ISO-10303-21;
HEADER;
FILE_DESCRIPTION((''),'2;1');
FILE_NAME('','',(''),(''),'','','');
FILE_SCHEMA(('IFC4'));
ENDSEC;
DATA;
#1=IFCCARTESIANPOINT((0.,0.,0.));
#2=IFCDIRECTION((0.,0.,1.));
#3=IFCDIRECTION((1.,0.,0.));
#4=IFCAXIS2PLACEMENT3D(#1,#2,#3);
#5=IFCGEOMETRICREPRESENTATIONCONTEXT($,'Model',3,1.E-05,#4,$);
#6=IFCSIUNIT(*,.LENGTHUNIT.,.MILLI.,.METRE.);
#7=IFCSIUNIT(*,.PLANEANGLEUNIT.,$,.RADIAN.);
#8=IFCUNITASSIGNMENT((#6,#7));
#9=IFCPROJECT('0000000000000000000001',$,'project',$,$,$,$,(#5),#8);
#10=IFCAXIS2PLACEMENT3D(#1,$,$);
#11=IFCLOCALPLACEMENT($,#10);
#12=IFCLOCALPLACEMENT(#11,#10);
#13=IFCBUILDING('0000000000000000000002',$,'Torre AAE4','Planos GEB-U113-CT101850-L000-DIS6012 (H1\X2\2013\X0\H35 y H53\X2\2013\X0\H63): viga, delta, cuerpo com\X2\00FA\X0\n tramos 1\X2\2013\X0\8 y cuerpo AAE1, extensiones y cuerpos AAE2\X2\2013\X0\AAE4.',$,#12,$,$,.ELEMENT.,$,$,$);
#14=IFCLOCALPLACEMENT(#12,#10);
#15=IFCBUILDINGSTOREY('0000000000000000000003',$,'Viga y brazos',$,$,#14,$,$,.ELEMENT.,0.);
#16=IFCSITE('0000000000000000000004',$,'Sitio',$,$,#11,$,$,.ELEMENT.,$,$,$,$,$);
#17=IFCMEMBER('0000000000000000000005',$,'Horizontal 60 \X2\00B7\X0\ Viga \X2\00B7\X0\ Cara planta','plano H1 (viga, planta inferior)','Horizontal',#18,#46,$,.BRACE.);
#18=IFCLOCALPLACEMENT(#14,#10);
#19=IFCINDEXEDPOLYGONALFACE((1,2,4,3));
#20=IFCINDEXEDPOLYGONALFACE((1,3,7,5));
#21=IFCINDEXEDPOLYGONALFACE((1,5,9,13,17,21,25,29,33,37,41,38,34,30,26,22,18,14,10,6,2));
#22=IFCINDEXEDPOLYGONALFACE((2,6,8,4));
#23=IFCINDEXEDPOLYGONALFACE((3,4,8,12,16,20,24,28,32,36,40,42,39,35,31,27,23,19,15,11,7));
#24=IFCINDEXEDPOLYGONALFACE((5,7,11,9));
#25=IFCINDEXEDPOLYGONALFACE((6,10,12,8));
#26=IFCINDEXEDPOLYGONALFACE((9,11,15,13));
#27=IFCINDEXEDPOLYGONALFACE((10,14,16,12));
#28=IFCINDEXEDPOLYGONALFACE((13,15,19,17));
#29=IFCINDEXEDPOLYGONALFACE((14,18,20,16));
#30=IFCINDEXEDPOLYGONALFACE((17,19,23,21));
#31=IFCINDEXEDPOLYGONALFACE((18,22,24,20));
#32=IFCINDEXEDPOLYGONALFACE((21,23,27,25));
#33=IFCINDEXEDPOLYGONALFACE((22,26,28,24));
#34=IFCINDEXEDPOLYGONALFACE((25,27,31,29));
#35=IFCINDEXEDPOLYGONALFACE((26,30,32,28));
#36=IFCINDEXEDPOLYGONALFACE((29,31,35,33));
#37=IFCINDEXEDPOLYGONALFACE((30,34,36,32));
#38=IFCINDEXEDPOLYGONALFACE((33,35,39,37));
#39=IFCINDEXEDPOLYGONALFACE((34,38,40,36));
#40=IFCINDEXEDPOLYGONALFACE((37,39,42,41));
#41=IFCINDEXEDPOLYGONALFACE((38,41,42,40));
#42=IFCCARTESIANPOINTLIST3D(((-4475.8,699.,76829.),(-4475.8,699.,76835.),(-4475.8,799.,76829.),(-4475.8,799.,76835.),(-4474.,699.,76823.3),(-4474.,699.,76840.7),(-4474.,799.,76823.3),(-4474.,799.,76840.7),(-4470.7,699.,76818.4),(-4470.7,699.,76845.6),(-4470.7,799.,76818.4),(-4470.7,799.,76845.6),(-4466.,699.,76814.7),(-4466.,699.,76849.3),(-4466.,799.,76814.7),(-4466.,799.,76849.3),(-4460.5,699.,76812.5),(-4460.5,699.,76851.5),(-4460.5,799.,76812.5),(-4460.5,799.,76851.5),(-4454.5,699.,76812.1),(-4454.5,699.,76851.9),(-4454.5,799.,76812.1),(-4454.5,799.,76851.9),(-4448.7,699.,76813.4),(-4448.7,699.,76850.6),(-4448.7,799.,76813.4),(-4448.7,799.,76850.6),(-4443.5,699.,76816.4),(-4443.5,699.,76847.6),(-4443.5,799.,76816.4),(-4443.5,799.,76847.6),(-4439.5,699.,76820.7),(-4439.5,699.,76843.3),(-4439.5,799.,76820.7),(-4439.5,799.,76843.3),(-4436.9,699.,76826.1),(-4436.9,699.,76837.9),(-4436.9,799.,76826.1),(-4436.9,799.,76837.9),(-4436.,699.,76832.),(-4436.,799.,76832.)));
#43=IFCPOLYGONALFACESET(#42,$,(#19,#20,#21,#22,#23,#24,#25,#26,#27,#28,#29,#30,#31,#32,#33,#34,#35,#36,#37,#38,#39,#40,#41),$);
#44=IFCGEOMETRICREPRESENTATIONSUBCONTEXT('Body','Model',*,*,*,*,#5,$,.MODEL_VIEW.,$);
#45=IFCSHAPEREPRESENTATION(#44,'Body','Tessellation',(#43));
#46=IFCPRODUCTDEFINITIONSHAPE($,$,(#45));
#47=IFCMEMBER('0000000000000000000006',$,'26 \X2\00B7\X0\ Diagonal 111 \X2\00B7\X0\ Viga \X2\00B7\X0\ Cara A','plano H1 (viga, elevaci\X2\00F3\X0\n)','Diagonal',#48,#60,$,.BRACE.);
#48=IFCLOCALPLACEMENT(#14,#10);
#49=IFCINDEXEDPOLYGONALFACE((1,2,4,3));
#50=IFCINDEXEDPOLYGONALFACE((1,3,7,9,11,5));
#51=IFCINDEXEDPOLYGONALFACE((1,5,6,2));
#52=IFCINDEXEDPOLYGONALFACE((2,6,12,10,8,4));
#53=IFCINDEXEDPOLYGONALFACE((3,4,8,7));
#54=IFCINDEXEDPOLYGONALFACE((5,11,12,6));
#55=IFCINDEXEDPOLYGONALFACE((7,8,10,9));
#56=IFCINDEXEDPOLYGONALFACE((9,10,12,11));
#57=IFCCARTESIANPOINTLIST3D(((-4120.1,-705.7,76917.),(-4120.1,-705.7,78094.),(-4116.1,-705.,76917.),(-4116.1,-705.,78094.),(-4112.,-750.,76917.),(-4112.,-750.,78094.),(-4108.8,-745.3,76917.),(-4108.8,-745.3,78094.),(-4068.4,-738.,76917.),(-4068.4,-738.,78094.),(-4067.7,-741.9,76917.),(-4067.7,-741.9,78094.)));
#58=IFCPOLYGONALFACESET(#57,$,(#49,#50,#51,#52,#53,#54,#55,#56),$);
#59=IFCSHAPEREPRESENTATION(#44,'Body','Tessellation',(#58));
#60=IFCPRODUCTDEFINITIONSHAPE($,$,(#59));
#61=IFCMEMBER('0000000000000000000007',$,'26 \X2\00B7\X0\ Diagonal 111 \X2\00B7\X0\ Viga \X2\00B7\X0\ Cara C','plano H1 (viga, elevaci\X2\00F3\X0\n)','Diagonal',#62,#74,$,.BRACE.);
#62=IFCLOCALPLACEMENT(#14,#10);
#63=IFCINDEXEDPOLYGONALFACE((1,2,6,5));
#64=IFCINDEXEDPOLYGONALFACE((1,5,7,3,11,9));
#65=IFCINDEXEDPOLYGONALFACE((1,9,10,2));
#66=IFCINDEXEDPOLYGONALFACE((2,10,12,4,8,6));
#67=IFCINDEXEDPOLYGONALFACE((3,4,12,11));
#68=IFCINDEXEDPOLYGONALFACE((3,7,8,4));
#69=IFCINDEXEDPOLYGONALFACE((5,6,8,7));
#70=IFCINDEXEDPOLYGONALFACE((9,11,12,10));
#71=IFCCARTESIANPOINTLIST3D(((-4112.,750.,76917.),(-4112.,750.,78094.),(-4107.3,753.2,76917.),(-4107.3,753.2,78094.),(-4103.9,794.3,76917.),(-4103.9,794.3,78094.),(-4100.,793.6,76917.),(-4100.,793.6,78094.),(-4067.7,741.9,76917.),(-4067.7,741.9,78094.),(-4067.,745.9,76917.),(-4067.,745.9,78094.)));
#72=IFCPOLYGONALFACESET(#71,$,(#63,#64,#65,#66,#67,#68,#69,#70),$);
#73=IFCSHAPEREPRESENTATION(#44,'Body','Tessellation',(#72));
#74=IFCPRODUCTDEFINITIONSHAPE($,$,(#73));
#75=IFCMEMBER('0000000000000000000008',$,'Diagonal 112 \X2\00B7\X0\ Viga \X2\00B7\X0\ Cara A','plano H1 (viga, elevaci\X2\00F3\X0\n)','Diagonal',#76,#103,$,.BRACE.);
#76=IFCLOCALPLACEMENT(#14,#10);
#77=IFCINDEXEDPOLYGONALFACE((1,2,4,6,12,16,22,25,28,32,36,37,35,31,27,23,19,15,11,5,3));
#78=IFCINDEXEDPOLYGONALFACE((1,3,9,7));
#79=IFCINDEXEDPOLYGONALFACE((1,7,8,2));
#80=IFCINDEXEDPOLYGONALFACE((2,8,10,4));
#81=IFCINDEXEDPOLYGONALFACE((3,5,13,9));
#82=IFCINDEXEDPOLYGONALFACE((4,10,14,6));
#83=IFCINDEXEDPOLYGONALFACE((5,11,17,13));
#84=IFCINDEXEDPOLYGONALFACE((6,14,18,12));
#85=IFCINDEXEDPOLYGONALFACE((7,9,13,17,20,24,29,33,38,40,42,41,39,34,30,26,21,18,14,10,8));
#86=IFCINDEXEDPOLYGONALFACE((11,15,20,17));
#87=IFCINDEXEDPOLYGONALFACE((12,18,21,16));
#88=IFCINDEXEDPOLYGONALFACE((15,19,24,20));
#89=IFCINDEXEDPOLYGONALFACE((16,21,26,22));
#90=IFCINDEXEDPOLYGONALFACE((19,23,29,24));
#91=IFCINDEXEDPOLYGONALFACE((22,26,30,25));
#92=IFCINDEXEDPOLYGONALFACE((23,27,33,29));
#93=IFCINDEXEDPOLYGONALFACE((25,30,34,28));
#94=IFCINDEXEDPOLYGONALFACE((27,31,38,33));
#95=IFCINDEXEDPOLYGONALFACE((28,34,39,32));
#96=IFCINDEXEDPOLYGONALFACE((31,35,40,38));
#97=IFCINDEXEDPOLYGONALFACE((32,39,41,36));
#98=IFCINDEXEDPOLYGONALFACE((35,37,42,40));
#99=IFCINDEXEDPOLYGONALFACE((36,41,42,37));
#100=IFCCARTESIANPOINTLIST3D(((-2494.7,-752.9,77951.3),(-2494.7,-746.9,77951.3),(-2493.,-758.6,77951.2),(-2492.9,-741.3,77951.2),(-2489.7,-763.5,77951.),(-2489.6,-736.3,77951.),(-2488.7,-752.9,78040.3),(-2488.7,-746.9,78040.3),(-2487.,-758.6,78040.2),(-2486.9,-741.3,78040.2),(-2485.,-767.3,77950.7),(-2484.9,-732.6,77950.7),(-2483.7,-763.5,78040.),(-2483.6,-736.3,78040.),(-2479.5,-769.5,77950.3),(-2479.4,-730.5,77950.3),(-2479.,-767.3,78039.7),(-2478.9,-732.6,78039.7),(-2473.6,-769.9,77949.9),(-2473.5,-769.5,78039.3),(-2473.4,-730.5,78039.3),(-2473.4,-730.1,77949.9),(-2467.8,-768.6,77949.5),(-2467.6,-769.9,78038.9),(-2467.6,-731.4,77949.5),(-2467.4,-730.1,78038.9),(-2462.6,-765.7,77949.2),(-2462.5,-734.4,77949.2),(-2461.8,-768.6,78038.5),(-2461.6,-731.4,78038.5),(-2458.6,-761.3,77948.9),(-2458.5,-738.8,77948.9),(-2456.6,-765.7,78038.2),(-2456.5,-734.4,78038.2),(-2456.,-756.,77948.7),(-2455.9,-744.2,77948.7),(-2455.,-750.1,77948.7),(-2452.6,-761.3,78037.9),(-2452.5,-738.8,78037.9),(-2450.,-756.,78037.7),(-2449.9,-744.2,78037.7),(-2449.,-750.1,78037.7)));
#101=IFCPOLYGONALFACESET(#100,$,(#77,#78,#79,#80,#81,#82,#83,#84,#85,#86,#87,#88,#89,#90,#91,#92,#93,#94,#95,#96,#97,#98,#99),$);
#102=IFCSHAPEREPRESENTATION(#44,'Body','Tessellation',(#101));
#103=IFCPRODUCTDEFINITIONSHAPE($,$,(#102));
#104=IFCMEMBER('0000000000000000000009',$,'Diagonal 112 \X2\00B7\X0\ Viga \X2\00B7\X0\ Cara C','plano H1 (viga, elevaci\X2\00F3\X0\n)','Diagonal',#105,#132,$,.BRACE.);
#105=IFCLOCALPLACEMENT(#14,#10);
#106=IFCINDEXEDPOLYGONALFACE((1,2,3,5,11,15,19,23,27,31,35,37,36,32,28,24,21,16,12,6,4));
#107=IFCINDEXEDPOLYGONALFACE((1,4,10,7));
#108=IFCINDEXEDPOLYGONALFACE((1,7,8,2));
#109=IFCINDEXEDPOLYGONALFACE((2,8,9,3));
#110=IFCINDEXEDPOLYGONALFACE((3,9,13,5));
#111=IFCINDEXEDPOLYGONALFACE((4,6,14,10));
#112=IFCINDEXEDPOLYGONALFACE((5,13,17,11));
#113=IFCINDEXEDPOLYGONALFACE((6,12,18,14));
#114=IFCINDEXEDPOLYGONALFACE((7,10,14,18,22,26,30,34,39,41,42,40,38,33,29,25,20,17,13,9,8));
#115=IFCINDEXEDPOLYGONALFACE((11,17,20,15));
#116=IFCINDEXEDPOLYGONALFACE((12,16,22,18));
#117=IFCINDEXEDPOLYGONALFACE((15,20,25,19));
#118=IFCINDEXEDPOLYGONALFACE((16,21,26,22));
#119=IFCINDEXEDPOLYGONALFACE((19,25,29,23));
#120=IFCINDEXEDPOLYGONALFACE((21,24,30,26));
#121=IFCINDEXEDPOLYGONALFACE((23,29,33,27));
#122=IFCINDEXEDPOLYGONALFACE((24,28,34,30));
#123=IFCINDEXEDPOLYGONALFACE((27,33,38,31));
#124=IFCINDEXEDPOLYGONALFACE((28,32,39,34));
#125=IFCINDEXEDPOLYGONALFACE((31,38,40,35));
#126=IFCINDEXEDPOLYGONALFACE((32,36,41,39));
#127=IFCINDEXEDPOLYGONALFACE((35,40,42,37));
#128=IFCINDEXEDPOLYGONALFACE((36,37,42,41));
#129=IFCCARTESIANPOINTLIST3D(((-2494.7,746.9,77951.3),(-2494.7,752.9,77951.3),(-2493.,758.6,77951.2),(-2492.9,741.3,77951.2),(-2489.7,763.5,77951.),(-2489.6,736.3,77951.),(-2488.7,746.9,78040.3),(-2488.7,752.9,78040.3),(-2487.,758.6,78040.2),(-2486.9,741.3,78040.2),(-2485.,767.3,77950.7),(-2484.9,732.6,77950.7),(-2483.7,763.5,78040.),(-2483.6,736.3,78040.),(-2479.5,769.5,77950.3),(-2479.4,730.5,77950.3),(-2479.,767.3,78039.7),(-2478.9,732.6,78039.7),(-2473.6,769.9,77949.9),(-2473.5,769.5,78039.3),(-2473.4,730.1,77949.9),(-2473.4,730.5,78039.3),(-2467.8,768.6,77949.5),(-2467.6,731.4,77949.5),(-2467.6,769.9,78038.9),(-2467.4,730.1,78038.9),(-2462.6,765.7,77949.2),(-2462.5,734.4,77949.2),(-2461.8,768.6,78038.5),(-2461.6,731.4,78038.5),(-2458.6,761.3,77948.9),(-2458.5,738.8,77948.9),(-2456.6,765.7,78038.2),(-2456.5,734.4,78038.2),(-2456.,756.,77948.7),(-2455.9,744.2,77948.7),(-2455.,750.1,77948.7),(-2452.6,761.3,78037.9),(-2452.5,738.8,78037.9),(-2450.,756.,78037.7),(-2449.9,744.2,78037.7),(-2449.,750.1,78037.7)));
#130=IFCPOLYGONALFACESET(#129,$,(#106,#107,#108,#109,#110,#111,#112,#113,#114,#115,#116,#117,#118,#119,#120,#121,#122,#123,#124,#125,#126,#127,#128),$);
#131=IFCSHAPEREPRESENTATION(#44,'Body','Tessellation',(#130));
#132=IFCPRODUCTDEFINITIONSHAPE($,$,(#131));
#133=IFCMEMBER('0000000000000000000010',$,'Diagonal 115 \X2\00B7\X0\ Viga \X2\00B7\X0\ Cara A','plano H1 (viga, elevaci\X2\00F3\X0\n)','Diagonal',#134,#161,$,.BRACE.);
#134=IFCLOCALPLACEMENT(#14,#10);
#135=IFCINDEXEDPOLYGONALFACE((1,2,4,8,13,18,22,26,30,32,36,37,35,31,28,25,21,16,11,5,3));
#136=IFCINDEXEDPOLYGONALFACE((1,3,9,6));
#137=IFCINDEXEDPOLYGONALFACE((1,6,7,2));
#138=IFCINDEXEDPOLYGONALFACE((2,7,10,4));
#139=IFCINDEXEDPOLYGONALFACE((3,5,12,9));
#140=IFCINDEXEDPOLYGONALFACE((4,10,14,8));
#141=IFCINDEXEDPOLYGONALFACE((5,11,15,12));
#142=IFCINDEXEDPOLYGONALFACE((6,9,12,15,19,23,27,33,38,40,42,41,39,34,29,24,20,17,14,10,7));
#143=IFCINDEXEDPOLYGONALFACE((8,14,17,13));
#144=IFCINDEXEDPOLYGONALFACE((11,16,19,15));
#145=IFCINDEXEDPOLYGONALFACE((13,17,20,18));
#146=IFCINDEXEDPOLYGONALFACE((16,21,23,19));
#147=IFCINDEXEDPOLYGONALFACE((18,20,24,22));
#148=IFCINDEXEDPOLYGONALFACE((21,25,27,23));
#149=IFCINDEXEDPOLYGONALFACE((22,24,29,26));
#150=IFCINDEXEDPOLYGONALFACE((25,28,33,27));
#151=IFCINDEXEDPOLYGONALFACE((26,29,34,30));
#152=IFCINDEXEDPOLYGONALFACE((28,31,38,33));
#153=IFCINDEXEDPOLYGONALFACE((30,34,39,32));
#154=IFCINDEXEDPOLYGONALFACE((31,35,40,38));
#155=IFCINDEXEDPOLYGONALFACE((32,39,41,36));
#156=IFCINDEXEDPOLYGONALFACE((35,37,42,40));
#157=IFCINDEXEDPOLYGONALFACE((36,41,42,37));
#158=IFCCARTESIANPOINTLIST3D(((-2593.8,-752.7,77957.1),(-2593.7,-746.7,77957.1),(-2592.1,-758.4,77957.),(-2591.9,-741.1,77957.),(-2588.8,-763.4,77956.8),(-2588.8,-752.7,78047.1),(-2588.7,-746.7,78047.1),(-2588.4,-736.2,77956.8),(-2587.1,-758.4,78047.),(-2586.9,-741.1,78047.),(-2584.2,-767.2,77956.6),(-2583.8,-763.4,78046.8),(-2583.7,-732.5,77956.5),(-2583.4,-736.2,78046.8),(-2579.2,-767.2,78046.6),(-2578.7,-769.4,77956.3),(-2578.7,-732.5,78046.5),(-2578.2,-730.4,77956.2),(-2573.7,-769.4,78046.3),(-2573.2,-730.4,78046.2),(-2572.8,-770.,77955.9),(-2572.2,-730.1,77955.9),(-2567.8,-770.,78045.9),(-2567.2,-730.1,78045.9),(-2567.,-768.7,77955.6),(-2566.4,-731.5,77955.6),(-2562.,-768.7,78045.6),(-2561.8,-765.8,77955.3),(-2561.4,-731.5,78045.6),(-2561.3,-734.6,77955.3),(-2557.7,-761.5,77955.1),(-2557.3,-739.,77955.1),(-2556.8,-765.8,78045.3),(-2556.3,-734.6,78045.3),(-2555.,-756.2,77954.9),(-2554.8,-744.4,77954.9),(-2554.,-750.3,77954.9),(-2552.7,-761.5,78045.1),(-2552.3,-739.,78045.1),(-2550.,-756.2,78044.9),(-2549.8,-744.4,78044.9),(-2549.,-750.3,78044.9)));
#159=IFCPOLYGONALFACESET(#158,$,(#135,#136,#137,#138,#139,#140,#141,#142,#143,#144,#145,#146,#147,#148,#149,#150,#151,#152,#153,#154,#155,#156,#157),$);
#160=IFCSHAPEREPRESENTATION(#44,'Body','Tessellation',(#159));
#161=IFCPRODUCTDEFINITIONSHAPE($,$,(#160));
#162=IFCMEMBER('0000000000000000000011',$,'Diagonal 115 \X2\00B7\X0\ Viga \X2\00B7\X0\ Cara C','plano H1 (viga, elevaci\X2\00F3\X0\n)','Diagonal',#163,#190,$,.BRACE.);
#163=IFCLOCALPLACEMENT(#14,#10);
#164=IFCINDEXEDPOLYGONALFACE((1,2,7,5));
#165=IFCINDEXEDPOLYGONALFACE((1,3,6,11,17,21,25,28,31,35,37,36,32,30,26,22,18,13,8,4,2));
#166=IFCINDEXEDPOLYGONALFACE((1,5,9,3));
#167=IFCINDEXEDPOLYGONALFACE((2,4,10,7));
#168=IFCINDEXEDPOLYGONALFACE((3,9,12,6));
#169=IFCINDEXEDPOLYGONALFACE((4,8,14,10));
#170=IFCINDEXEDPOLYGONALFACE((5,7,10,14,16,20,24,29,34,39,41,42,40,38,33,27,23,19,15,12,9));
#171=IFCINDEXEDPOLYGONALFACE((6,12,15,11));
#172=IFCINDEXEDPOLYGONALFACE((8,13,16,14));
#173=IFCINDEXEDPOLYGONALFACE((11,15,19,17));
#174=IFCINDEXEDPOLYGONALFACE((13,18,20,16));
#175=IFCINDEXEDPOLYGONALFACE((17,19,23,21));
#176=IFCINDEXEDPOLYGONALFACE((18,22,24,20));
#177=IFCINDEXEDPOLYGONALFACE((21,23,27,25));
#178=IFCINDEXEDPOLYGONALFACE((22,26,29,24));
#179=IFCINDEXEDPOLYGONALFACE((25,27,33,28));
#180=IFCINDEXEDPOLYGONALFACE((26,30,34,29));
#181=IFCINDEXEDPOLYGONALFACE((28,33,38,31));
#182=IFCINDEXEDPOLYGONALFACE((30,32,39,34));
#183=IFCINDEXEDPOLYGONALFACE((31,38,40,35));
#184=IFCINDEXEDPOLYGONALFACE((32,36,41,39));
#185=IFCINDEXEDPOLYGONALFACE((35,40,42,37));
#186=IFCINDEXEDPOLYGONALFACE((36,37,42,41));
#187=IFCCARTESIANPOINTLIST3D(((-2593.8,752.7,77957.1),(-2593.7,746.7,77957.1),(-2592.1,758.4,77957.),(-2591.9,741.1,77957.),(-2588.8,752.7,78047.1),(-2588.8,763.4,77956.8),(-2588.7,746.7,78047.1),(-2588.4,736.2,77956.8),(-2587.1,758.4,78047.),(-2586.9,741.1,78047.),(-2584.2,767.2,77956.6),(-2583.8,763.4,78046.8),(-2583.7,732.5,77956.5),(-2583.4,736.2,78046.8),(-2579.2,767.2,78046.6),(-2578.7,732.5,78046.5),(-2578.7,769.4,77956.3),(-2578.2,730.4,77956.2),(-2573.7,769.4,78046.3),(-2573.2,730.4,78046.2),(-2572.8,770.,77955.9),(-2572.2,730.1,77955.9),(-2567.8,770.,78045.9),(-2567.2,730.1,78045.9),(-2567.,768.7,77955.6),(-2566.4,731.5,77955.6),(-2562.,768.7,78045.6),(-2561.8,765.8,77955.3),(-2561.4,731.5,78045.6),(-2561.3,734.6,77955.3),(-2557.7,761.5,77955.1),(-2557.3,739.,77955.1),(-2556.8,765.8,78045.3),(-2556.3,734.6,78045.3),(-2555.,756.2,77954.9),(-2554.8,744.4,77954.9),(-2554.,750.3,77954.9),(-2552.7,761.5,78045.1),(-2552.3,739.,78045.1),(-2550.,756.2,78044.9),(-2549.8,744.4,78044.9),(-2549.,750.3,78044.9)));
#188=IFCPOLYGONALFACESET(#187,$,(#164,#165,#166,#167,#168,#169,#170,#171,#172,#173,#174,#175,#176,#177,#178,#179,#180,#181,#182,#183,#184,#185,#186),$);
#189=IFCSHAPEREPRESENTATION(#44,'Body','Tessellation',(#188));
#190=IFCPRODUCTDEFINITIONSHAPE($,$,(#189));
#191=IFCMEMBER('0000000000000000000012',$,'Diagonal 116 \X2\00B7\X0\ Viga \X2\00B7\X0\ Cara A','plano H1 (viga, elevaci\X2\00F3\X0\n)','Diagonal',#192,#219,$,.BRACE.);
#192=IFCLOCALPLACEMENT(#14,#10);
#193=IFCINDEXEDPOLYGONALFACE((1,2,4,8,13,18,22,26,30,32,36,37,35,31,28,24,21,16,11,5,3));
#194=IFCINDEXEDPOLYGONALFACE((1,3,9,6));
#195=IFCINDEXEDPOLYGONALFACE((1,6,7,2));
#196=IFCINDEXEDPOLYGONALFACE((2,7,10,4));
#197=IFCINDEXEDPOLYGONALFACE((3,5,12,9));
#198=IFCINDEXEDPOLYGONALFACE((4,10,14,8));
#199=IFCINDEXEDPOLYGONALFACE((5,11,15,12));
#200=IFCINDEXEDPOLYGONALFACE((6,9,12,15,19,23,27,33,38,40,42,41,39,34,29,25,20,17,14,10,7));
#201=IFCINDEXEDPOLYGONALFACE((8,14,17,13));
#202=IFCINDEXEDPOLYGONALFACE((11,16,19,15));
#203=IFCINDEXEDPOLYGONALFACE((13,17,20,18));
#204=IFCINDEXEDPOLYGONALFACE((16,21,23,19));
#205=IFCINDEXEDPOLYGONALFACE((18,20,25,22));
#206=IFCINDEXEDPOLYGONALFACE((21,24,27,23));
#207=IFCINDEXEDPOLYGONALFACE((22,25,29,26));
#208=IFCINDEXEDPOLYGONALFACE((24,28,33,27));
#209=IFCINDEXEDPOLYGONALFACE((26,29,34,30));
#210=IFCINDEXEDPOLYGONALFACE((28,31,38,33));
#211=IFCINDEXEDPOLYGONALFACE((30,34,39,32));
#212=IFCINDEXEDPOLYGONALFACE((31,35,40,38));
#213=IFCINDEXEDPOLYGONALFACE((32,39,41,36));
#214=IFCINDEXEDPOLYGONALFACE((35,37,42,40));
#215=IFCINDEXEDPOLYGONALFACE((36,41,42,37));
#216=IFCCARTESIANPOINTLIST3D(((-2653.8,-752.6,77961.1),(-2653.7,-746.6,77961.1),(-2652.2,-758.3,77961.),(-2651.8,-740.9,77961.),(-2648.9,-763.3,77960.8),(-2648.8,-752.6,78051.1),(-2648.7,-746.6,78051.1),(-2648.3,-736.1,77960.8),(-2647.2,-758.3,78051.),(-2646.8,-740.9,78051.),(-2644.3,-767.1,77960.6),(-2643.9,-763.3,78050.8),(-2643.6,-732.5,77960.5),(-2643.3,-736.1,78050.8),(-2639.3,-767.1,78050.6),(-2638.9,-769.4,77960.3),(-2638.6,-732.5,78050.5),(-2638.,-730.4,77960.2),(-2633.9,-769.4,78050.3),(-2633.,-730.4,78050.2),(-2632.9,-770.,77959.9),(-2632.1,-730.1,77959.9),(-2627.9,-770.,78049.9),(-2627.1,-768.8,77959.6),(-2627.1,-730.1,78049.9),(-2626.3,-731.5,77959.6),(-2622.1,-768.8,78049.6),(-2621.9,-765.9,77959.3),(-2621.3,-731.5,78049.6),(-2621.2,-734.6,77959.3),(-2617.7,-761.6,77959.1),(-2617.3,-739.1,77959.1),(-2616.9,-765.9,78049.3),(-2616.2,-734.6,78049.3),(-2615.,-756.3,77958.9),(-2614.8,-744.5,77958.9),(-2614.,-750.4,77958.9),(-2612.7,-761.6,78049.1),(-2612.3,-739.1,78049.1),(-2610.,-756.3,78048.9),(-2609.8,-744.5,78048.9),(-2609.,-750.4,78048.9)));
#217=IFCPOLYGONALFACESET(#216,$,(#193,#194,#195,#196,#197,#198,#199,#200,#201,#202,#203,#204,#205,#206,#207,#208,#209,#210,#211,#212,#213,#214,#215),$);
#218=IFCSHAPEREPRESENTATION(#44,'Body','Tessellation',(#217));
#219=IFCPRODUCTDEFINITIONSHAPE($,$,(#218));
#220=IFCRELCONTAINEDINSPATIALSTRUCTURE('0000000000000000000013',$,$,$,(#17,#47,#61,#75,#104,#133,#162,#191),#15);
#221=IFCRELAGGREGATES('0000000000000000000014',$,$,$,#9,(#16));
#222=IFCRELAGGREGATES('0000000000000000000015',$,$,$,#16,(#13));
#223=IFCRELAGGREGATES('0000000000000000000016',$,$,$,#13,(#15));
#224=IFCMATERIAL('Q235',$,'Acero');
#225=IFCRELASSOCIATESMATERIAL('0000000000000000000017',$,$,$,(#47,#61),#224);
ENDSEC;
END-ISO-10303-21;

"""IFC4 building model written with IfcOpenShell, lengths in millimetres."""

from ifc_helpers import new_model, si_unit, frame, frame_2d, origin, origin_with_axes, place, context, subcontext, project, spatial, circle, l_section, extrude, material, element, save


model = new_model("IFC4")

# Units and contexts
model_context = context("Model", 3, precision=1e-05, world=origin_with_axes())
body_context = subcontext(model_context, "Body", "Model", "MODEL_VIEW")
ifc_project = project(units=[si_unit("LENGTHUNIT", "METRE", prefix="MILLI"), si_unit("PLANEANGLEUNIT", "RADIAN")], contexts=[model_context])

# Site, building, storey
site_placement = place(None, origin())
site = spatial("IfcSite", under=ifc_project, at=site_placement, Name="Sitio", CompositionType="ELEMENT")
building_placement = place(site_placement, origin())
building = spatial("IfcBuilding", under=site, at=building_placement, Name="Torre AAE4", Description="Planos GEB-U113-CT101850-L000-DIS6012 (H1–H35 y H53–H63): viga, delta, cuerpo común tramos 1–8 y cuerpo AAE1, extensiones y cuerpos AAE2–AAE4.", CompositionType="ELEMENT")
storey_placement = place(building_placement, origin())
storey = spatial("IfcBuildingStorey", under=building, at=storey_placement, Name="Viga y brazos", CompositionType="ELEMENT", Elevation=0.0)

# Members
ifc_material = material(Name="Q235", Category="Acero")
member_1_placement = place(storey_placement, frame((-4456.0, 699.0, 76832.0), z_axis=(0.0, 1.0, 0.0), x_axis=(1.0, 0.0, 0.0)))
element("IfcMember", 1, at=member_1_placement, inside=storey, Name="Horizontal 60 · Viga · Cara planta", Description="plano H1 (viga, planta inferior)", ObjectType="Horizontal", PredefinedType="BRACE", context=body_context, shape_type="SweptSolid", body=[
    extrude(circle(Radius=20.0), None, (0.0, 0.0, 1.0), 100.0),
])
for number, where, z_axis, x_axis, name in (
    (2, (-4112.0, -750.0, 76917.0), (0.0, 0.0, 1.0), (0.98377, 0.179433, 0.0), "26 · Diagonal 111 · Viga · Cara A"),
    (3, (-4112.0, 750.0, 76917.0), (0.0, 0.0, 1.0), (0.98377, -0.179433, 0.0), "26 · Diagonal 111 · Viga · Cara C"),
):
    element("IfcMember", number, at=place(storey_placement, frame(where, z_axis=z_axis, x_axis=x_axis)), inside=storey, material=ifc_material, Name=name, Description="plano H1 (viga, elevación)", ObjectType="Diagonal", PredefinedType="BRACE", context=body_context, shape_type="SweptSolid", body=[
        extrude(l_section(Depth=45.0, Width=45.0, Thickness=4.0, at=frame_2d((22.5, 22.5))), None, (0.0, 0.0, 1.0), 1177.0),
    ])
for number, where, z_axis, x_axis, name in (
    (4, (-2475.0, -750.0, 77950.0), (0.067263, 0.0, 0.997735), (0.954577, 0.290933, -0.064353), "Diagonal 112 · Viga · Cara A"),
    (5, (-2475.0, 750.0, 77950.0), (0.067263, 0.0, 0.997735), (0.954577, -0.290933, -0.064353), "Diagonal 112 · Viga · Cara C"),
):
    element("IfcMember", number, at=place(storey_placement, frame(where, z_axis=z_axis, x_axis=x_axis)), inside=storey, Name=name, Description="plano H1 (viga, elevación)", ObjectType="Diagonal", PredefinedType="BRACE", context=body_context, shape_type="SweptSolid", body=[
        extrude(circle(Radius=20.0), None, (0.0, 0.0, 1.0), 89.2),
    ])
for number, where, z_axis, x_axis, name in (
    (6, (-2574.0, -750.0, 77956.0), (0.05547, 0.0, 0.99846), (0.958408, 0.280391, -0.053245), "Diagonal 115 · Viga · Cara A"),
    (7, (-2574.0, 750.0, 77956.0), (0.05547, 0.0, 0.99846), (0.958408, -0.280391, -0.053245), "Diagonal 115 · Viga · Cara C"),
    (8, (-2634.0, -750.0, 77960.0), (0.05547, 0.0, 0.99846), (0.960111, 0.274484, -0.05334), "Diagonal 116 · Viga · Cara A"),
):
    element("IfcMember", number, at=place(storey_placement, frame(where, z_axis=z_axis, x_axis=x_axis)), inside=storey, Name=name, Description="plano H1 (viga, elevación)", ObjectType="Diagonal", PredefinedType="BRACE", context=body_context, shape_type="SweptSolid", body=[
        extrude(circle(Radius=20.0), None, (0.0, 0.0, 1.0), 90.1),
    ])

save(model, "model.ifc")
